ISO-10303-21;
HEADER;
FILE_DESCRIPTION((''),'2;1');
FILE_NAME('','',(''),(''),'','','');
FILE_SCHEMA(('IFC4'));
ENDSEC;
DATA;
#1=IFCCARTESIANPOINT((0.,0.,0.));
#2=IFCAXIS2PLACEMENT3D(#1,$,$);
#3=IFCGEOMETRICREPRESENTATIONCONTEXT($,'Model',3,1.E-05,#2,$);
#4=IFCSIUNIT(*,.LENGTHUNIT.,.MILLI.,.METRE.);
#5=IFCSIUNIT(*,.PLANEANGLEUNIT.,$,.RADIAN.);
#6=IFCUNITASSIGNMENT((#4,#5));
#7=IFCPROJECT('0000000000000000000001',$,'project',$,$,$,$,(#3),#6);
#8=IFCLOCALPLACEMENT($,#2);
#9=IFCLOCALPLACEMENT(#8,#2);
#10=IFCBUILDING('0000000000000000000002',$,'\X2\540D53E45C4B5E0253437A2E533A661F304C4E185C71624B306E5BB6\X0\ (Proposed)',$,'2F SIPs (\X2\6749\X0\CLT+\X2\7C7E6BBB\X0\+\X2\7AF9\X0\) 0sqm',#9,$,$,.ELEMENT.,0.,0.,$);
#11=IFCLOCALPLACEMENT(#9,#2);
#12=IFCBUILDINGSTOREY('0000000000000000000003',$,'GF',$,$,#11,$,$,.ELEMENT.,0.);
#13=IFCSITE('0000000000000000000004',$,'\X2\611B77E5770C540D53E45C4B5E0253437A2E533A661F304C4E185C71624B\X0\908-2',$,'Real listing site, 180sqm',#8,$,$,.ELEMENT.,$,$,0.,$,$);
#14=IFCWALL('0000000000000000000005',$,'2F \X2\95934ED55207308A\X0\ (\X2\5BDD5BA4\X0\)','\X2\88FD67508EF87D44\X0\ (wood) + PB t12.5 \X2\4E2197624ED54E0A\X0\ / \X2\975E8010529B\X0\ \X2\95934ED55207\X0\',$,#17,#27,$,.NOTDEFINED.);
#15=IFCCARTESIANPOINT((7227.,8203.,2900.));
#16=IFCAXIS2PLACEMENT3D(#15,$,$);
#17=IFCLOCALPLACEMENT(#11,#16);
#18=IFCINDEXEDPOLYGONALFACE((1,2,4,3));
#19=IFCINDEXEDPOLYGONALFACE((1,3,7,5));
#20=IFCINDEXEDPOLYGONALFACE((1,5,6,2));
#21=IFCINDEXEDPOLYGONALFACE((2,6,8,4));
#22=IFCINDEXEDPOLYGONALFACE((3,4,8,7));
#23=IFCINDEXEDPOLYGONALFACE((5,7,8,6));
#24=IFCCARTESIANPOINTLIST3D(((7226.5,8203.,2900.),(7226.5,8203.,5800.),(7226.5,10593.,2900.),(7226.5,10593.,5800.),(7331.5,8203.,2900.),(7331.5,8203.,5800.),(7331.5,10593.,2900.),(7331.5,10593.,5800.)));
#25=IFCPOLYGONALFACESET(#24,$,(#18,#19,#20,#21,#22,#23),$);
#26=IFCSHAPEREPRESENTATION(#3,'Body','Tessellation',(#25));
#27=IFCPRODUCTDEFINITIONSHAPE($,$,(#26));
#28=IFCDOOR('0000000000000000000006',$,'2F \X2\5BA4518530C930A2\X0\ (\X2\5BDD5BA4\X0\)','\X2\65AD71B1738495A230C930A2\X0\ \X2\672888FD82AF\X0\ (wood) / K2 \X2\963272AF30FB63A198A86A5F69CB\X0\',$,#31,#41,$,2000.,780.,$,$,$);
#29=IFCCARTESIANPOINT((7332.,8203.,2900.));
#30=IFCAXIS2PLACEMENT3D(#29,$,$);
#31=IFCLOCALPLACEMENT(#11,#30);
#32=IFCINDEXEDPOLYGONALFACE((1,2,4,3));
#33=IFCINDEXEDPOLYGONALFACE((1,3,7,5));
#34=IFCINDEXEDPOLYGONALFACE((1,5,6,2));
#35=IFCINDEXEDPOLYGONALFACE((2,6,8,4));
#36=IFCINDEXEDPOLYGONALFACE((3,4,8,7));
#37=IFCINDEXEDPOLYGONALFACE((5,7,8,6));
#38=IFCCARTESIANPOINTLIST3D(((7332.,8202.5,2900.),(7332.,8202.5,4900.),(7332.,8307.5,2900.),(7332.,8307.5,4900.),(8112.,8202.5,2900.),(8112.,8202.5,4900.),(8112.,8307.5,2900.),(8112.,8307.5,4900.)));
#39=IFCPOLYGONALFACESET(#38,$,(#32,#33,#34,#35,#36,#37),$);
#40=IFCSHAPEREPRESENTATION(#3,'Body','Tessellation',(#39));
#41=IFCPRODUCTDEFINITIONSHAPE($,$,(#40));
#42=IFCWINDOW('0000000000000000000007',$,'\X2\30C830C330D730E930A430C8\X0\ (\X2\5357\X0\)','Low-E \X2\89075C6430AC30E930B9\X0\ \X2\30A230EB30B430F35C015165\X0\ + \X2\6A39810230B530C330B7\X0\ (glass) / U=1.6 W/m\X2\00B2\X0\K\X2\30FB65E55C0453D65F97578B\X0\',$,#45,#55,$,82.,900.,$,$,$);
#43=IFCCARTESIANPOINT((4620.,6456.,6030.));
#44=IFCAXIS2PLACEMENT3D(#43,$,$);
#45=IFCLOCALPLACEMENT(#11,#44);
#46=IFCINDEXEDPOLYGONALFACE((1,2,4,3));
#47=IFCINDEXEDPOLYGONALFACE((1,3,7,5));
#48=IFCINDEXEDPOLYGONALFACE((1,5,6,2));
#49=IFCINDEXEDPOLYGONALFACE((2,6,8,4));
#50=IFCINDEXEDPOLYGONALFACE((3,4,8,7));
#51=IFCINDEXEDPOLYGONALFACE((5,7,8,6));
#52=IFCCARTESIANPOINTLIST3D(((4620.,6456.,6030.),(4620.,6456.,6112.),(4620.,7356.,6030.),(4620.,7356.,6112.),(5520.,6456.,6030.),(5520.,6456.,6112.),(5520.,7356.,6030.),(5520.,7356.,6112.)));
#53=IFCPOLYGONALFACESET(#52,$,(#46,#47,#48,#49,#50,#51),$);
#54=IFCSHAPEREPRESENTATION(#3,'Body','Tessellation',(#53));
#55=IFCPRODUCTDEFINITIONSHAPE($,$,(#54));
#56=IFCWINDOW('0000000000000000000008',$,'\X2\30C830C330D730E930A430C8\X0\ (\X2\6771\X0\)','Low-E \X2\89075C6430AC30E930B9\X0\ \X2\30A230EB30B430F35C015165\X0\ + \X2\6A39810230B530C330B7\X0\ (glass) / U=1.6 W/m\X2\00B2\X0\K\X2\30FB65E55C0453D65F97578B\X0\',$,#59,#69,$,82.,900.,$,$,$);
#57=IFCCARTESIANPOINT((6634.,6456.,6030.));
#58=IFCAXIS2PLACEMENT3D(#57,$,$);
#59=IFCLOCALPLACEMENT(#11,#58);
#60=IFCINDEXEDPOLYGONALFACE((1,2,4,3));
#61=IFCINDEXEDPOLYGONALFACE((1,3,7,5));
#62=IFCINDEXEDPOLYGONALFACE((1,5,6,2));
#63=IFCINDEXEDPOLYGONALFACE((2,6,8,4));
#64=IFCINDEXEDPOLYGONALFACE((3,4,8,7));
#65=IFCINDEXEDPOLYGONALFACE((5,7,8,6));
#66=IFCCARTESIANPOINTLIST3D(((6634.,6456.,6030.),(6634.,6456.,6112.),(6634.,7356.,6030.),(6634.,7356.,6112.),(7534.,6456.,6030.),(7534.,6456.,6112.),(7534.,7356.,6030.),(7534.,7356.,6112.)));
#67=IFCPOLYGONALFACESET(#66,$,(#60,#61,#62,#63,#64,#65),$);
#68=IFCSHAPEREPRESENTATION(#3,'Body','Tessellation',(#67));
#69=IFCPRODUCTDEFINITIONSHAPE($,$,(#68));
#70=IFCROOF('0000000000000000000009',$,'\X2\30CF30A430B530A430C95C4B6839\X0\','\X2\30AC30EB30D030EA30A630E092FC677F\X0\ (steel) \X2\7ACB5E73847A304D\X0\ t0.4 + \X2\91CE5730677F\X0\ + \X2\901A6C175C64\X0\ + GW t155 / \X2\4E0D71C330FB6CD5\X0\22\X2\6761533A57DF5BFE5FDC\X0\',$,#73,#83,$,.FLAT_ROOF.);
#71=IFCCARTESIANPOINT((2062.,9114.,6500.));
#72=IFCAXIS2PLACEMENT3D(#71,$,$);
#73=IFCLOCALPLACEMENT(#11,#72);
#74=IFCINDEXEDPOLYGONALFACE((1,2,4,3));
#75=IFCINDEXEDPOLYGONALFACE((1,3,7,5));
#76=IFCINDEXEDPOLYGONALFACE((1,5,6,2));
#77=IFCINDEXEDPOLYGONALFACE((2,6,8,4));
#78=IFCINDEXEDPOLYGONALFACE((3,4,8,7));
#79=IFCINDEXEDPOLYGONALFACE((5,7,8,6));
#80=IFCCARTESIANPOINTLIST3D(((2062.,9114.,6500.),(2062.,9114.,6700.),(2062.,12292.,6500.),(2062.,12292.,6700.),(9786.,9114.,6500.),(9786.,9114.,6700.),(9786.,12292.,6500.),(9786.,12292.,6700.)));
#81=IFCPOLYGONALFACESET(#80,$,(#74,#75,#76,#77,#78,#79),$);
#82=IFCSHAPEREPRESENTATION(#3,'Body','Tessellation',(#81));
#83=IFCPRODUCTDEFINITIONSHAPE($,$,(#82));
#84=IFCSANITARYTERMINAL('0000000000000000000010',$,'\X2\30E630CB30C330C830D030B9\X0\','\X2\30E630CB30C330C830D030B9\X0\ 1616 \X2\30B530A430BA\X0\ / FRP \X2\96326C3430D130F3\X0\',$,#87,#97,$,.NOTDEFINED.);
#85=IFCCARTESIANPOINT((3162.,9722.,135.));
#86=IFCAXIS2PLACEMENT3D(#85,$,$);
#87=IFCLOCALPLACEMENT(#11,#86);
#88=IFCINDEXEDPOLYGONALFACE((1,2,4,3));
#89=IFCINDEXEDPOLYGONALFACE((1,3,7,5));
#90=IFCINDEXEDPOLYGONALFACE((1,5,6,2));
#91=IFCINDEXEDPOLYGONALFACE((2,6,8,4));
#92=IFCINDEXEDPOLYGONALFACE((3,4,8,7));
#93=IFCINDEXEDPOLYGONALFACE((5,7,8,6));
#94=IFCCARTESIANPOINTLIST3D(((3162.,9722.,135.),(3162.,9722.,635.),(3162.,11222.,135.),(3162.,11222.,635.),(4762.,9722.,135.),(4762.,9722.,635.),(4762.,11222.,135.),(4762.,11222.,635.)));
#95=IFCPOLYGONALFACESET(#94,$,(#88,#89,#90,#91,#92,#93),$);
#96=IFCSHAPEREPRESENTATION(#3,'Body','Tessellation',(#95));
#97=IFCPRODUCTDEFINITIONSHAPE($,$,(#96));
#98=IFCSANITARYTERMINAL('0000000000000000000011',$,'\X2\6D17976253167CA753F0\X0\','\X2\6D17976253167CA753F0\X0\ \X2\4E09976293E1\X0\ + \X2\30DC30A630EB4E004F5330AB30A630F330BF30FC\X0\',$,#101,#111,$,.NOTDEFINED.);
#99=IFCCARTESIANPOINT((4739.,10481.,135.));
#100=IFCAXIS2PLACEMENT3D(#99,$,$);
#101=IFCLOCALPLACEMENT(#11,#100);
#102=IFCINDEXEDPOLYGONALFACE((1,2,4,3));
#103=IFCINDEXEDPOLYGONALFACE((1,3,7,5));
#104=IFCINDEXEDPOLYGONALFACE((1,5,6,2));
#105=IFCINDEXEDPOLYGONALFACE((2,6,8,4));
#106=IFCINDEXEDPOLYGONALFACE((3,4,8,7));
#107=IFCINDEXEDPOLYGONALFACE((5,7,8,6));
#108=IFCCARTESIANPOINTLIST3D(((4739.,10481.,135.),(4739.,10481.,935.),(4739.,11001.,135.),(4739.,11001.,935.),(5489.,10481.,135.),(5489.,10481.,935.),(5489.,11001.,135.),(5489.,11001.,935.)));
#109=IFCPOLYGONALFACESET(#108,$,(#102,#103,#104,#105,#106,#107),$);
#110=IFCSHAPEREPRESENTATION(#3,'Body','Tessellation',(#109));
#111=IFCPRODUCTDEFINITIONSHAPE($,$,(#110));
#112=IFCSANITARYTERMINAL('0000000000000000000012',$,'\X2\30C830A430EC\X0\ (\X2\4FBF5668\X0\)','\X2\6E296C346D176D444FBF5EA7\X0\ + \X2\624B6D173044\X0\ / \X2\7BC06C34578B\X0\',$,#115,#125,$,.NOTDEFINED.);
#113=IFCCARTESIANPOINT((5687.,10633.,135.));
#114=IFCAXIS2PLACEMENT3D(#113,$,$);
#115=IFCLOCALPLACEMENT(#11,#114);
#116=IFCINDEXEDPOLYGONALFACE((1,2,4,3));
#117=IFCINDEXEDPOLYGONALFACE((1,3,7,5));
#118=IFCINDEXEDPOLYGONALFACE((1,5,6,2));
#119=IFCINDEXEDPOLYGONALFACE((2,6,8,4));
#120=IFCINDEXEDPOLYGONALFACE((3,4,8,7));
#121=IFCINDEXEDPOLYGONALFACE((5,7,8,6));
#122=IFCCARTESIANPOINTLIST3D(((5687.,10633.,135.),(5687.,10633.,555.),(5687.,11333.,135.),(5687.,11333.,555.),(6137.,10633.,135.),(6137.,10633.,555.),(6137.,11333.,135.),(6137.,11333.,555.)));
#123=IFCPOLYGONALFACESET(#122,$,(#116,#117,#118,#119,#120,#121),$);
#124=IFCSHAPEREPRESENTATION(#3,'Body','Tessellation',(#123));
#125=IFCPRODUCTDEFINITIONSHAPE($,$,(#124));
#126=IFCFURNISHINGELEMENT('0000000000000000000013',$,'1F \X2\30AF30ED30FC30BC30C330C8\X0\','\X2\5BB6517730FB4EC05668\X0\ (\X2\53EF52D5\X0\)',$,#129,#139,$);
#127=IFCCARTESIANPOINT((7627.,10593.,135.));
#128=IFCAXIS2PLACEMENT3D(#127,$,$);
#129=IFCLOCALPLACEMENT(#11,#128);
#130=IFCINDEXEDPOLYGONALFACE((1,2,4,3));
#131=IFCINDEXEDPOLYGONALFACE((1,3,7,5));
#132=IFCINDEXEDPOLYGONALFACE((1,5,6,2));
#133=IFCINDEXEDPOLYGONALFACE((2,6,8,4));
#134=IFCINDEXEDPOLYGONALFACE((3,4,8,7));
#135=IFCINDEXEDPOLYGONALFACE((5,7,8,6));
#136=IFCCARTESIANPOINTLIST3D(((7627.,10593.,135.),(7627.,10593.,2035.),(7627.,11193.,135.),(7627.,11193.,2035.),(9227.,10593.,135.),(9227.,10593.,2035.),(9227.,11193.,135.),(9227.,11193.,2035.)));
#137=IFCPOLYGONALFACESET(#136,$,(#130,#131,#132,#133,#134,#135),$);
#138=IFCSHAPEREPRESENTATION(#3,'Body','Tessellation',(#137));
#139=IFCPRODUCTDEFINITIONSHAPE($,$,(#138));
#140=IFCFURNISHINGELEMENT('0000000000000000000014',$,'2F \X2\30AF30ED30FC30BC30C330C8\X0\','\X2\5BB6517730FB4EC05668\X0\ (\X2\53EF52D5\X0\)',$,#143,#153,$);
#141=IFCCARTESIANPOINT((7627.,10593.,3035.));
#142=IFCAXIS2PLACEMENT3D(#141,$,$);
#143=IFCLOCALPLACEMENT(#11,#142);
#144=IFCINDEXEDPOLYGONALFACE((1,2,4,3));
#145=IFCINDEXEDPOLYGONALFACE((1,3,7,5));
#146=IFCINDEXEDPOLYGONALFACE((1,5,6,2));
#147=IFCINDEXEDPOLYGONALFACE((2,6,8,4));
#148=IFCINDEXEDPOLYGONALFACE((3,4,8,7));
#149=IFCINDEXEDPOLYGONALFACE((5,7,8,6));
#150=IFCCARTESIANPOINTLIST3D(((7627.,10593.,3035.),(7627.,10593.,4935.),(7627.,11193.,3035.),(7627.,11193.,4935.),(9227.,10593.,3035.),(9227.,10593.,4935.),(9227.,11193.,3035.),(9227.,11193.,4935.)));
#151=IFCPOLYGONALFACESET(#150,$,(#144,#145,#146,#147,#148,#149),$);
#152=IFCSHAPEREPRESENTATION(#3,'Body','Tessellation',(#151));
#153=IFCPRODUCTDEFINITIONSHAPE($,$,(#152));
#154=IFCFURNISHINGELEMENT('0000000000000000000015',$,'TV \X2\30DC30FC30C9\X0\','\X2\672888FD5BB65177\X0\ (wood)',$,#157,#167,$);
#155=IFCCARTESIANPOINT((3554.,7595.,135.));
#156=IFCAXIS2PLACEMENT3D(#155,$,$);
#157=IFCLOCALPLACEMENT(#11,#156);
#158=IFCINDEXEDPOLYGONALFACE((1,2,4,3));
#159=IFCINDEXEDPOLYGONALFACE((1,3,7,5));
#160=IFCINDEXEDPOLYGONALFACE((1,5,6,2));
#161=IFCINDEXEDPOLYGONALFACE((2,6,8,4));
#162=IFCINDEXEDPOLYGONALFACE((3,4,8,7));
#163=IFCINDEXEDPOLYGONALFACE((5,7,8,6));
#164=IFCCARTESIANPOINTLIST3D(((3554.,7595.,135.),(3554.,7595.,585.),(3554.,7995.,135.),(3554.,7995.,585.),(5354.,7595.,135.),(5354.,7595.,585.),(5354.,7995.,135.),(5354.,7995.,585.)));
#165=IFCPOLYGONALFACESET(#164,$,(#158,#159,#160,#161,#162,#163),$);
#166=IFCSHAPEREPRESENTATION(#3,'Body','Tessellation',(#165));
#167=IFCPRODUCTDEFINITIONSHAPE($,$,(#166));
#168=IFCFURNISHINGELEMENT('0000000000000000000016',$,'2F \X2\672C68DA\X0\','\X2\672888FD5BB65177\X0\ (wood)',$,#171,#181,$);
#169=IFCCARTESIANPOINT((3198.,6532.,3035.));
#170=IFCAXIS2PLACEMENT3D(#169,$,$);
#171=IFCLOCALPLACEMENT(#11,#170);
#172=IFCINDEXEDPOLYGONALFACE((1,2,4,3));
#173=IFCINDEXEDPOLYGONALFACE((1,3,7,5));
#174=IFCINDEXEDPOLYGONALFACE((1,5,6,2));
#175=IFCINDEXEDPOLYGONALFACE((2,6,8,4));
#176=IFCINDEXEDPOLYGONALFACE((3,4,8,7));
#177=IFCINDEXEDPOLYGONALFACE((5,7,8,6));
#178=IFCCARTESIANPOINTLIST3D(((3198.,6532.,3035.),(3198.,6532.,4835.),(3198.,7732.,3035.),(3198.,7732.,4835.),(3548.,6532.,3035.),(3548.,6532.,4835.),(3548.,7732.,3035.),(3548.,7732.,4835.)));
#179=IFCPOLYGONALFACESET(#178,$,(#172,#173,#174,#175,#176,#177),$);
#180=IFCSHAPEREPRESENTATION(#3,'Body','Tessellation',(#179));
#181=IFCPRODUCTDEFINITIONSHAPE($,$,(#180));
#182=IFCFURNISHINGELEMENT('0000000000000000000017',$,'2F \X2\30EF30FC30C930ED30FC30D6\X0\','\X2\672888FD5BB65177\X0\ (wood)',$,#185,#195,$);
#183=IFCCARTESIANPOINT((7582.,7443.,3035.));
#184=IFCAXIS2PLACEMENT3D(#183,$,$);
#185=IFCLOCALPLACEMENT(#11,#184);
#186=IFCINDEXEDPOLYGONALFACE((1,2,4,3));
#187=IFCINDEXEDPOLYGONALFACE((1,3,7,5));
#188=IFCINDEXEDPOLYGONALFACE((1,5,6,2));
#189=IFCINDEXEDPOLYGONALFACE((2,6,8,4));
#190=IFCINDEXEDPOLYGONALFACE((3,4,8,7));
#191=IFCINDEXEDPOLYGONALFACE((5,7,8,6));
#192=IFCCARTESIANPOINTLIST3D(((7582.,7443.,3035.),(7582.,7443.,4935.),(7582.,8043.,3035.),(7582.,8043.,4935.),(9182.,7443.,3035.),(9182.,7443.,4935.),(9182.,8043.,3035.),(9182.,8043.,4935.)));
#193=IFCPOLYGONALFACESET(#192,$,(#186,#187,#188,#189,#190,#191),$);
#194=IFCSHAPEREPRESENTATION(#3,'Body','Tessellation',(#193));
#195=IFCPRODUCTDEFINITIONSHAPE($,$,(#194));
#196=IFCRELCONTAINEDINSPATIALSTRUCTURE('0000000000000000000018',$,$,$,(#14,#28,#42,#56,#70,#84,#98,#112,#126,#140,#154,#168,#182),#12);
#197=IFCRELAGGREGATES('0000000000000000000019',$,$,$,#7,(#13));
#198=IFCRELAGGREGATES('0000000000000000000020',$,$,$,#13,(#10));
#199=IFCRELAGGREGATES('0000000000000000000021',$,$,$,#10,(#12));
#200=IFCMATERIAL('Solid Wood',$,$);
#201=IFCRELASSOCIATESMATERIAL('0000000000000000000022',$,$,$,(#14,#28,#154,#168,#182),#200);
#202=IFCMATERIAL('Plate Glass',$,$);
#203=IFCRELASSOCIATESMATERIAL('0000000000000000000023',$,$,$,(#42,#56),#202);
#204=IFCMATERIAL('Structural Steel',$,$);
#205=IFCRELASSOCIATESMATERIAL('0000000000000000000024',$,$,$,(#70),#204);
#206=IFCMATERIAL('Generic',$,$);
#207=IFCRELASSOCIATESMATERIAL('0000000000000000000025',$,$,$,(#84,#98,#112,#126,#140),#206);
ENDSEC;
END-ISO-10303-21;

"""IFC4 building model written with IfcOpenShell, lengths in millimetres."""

from ifc_helpers import new_model, si_unit, frame, frame_2d, origin, place, context, project, spatial, rectangle, extrude, material, element, save


model = new_model("IFC4")

# Units and contexts
model_context = context("Model", 3, precision=1e-05, world=origin())
ifc_project = project(units=[si_unit("LENGTHUNIT", "METRE", prefix="MILLI"), si_unit("PLANEANGLEUNIT", "RADIAN")], contexts=[model_context])

# Site, building, storey
site_placement = place(None, origin())
site = spatial("IfcSite", under=ifc_project, at=site_placement, Name="愛知県名古屋市千種区星が丘山手908-2", ObjectType="Real listing site, 180sqm", CompositionType="ELEMENT", RefElevation=0.0)
building_placement = place(site_placement, origin())
building = spatial("IfcBuilding", under=site, at=building_placement, Name="名古屋市千種区星が丘山手の家 (Proposed)", ObjectType="2F SIPs (杉CLT+籾殻+竹) 0sqm", CompositionType="ELEMENT", ElevationOfRefHeight=0.0, ElevationOfTerrain=0.0)
storey_placement = place(building_placement, origin())
storey = spatial("IfcBuildingStorey", under=building, at=storey_placement, Name="GF", CompositionType="ELEMENT", Elevation=0.0)

# Shared definitions
ifc_material_1 = material(Name="Solid Wood")
ifc_material_2 = material(Name="Plate Glass")

# Wall
wall_1_placement = place(storey_placement, frame((7227.0, 8203.0, 2900.0)))
element("IfcWall", 1, at=wall_1_placement, inside=storey, material=ifc_material_1, Name="2F 間仕切り (寝室)", Description="製材軸組 (wood) + PB t12.5 両面仕上 / 非耐力 間仕切", PredefinedType="NOTDEFINED", context=model_context, shape_type="SweptSolid", body=[
    extrude(rectangle(XDim=105.0, YDim=2390.0, at=frame_2d((52.0, 1195.0))), frame((7227.0, 8203.0, 2900.0)), (0.0, 0.0, 1.0), 2900.0),
])

# Door
door_1_placement = place(storey_placement, frame((7332.0, 8203.0, 2900.0)))
element("IfcDoor", 2, at=door_1_placement, inside=storey, material=ifc_material_1, Name="2F 室内ドア (寝室)", Description="断熱玄関ドア 木製芯 (wood) / K2 防犯・採風機構", OverallHeight=2000.0, OverallWidth=780.0, context=model_context, shape_type="SweptSolid", body=[
    extrude(rectangle(XDim=780.0, YDim=105.0, at=frame_2d((390.0, 52.0))), frame((7332.0, 8203.0, 2900.0)), (0.0, 0.0, 1.0), 2000.0),
])

# Windows
window_1_placement = place(storey_placement, frame((4620.0, 6456.0, 6030.0)))
element("IfcWindow", 3, at=window_1_placement, inside=storey, material=ifc_material_2, Name="トップライト (南)", Description="Low-E 複層ガラス アルゴン封入 + 樹脂サッシ (glass) / U=1.6 W/m²K・日射取得型", OverallHeight=82.0, OverallWidth=900.0, context=model_context, shape_type="SweptSolid", body=[
    extrude(rectangle(XDim=900.0, YDim=900.0, at=frame_2d((450.0, 450.0))), frame((4620.0, 6456.0, 6030.0)), (0.0, 0.0, 1.0), 82.0),
])
window_2_placement = place(storey_placement, frame((6634.0, 6456.0, 6030.0)))
element("IfcWindow", 4, at=window_2_placement, inside=storey, material=ifc_material_2, Name="トップライト (東)", Description="Low-E 複層ガラス アルゴン封入 + 樹脂サッシ (glass) / U=1.6 W/m²K・日射取得型", OverallHeight=82.0, OverallWidth=900.0, context=model_context, shape_type="SweptSolid", body=[
    extrude(rectangle(XDim=900.0, YDim=900.0, at=frame_2d((450.0, 450.0))), frame((6634.0, 6456.0, 6030.0)), (0.0, 0.0, 1.0), 82.0),
])

# Roof
ifc_material_3 = material(Name="Structural Steel")
roof_placement = place(storey_placement, frame((2062.0, 9114.0, 6500.0)))
element("IfcRoof", 5, at=roof_placement, inside=storey, material=ifc_material_3, Name="ハイサイド屋根", Description="ガルバリウム鋼板 (steel) 立平葺き t0.4 + 野地板 + 通気層 + GW t155 / 不燃・法22条区域対応", PredefinedType="FLAT_ROOF", context=model_context, shape_type="SweptSolid", body=[
    extrude(rectangle(XDim=7724.0, YDim=3178.0, at=frame_2d((3862.0, 1589.0))), frame((2062.0, 9114.0, 6500.0)), (0.0, 0.0, 1.0), 200.0),
])

# Sanitary terminals
ifc_material_4 = material(Name="Generic")
sanitary_terminal_1_placement = place(storey_placement, frame((3162.0, 9722.0, 135.0)))
element("IfcSanitaryTerminal", 6, at=sanitary_terminal_1_placement, inside=storey, material=ifc_material_4, Name="ユニットバス", Description="ユニットバス 1616 サイズ / FRP 防水パン", PredefinedType="NOTDEFINED", context=model_context, shape_type="SweptSolid", body=[
    extrude(rectangle(XDim=1600.0, YDim=1500.0, at=frame_2d((800.0, 750.0))), frame((3162.0, 9722.0, 135.0)), (0.0, 0.0, 1.0), 500.0),
])
sanitary_terminal_2_placement = place(storey_placement, frame((4739.0, 10481.0, 135.0)))
element("IfcSanitaryTerminal", 7, at=sanitary_terminal_2_placement, inside=storey, material=ifc_material_4, Name="洗面化粧台", Description="洗面化粧台 三面鏡 + ボウル一体カウンター", PredefinedType="NOTDEFINED", context=model_context, shape_type="SweptSolid", body=[
    extrude(rectangle(XDim=750.0, YDim=520.0, at=frame_2d((375.0, 260.0))), frame((4739.0, 10481.0, 135.0)), (0.0, 0.0, 1.0), 800.0),
])
sanitary_terminal_3_placement = place(storey_placement, frame((5687.0, 10633.0, 135.0)))
element("IfcSanitaryTerminal", 8, at=sanitary_terminal_3_placement, inside=storey, material=ifc_material_4, Name="トイレ (便器)", Description="温水洗浄便座 + 手洗い / 節水型", PredefinedType="NOTDEFINED", context=model_context, shape_type="SweptSolid", body=[
    extrude(rectangle(XDim=450.0, YDim=700.0, at=frame_2d((225.0, 350.0))), frame((5687.0, 10633.0, 135.0)), (0.0, 0.0, 1.0), 420.0),
])

# Furnishing elements
furnishing_1_placement = place(storey_placement, frame((7627.0, 10593.0, 135.0)))
element("IfcFurnishingElement", 9, at=furnishing_1_placement, inside=storey, material=ifc_material_4, Name="1F クローゼット", Description="家具・什器 (可動)", context=model_context, shape_type="SweptSolid", body=[
    extrude(rectangle(XDim=1600.0, YDim=600.0, at=frame_2d((800.0, 300.0))), frame((7627.0, 10593.0, 135.0)), (0.0, 0.0, 1.0), 1900.0),
])
furnishing_2_placement = place(storey_placement, frame((7627.0, 10593.0, 3035.0)))
element("IfcFurnishingElement", 10, at=furnishing_2_placement, inside=storey, material=ifc_material_4, Name="2F クローゼット", Description="家具・什器 (可動)", context=model_context, shape_type="SweptSolid", body=[
    extrude(rectangle(XDim=1600.0, YDim=600.0, at=frame_2d((800.0, 300.0))), frame((7627.0, 10593.0, 3035.0)), (0.0, 0.0, 1.0), 1900.0),
])
furnishing_3_placement = place(storey_placement, frame((3554.0, 7595.0, 135.0)))
element("IfcFurnishingElement", 11, at=furnishing_3_placement, inside=storey, material=ifc_material_1, Name="TV ボード", Description="木製家具 (wood)", context=model_context, shape_type="SweptSolid", body=[
    extrude(rectangle(XDim=1800.0, YDim=400.0, at=frame_2d((900.0, 200.0))), frame((3554.0, 7595.0, 135.0)), (0.0, 0.0, 1.0), 450.0),
])
furnishing_4_placement = place(storey_placement, frame((3198.0, 6532.0, 3035.0)))
element("IfcFurnishingElement", 12, at=furnishing_4_placement, inside=storey, material=ifc_material_1, Name="2F 本棚", Description="木製家具 (wood)", context=model_context, shape_type="SweptSolid", body=[
    extrude(rectangle(XDim=350.0, YDim=1200.0, at=frame_2d((175.0, 600.0))), frame((3198.0, 6532.0, 3035.0)), (0.0, 0.0, 1.0), 1800.0),
])
furnishing_5_placement = place(storey_placement, frame((7582.0, 7443.0, 3035.0)))
element("IfcFurnishingElement", 13, at=furnishing_5_placement, inside=storey, material=ifc_material_1, Name="2F ワードローブ", Description="木製家具 (wood)", context=model_context, shape_type="SweptSolid", body=[
    extrude(rectangle(XDim=1600.0, YDim=600.0, at=frame_2d((800.0, 300.0))), frame((7582.0, 7443.0, 3035.0)), (0.0, 0.0, 1.0), 1900.0),
])

save(model, "model.ifc")
